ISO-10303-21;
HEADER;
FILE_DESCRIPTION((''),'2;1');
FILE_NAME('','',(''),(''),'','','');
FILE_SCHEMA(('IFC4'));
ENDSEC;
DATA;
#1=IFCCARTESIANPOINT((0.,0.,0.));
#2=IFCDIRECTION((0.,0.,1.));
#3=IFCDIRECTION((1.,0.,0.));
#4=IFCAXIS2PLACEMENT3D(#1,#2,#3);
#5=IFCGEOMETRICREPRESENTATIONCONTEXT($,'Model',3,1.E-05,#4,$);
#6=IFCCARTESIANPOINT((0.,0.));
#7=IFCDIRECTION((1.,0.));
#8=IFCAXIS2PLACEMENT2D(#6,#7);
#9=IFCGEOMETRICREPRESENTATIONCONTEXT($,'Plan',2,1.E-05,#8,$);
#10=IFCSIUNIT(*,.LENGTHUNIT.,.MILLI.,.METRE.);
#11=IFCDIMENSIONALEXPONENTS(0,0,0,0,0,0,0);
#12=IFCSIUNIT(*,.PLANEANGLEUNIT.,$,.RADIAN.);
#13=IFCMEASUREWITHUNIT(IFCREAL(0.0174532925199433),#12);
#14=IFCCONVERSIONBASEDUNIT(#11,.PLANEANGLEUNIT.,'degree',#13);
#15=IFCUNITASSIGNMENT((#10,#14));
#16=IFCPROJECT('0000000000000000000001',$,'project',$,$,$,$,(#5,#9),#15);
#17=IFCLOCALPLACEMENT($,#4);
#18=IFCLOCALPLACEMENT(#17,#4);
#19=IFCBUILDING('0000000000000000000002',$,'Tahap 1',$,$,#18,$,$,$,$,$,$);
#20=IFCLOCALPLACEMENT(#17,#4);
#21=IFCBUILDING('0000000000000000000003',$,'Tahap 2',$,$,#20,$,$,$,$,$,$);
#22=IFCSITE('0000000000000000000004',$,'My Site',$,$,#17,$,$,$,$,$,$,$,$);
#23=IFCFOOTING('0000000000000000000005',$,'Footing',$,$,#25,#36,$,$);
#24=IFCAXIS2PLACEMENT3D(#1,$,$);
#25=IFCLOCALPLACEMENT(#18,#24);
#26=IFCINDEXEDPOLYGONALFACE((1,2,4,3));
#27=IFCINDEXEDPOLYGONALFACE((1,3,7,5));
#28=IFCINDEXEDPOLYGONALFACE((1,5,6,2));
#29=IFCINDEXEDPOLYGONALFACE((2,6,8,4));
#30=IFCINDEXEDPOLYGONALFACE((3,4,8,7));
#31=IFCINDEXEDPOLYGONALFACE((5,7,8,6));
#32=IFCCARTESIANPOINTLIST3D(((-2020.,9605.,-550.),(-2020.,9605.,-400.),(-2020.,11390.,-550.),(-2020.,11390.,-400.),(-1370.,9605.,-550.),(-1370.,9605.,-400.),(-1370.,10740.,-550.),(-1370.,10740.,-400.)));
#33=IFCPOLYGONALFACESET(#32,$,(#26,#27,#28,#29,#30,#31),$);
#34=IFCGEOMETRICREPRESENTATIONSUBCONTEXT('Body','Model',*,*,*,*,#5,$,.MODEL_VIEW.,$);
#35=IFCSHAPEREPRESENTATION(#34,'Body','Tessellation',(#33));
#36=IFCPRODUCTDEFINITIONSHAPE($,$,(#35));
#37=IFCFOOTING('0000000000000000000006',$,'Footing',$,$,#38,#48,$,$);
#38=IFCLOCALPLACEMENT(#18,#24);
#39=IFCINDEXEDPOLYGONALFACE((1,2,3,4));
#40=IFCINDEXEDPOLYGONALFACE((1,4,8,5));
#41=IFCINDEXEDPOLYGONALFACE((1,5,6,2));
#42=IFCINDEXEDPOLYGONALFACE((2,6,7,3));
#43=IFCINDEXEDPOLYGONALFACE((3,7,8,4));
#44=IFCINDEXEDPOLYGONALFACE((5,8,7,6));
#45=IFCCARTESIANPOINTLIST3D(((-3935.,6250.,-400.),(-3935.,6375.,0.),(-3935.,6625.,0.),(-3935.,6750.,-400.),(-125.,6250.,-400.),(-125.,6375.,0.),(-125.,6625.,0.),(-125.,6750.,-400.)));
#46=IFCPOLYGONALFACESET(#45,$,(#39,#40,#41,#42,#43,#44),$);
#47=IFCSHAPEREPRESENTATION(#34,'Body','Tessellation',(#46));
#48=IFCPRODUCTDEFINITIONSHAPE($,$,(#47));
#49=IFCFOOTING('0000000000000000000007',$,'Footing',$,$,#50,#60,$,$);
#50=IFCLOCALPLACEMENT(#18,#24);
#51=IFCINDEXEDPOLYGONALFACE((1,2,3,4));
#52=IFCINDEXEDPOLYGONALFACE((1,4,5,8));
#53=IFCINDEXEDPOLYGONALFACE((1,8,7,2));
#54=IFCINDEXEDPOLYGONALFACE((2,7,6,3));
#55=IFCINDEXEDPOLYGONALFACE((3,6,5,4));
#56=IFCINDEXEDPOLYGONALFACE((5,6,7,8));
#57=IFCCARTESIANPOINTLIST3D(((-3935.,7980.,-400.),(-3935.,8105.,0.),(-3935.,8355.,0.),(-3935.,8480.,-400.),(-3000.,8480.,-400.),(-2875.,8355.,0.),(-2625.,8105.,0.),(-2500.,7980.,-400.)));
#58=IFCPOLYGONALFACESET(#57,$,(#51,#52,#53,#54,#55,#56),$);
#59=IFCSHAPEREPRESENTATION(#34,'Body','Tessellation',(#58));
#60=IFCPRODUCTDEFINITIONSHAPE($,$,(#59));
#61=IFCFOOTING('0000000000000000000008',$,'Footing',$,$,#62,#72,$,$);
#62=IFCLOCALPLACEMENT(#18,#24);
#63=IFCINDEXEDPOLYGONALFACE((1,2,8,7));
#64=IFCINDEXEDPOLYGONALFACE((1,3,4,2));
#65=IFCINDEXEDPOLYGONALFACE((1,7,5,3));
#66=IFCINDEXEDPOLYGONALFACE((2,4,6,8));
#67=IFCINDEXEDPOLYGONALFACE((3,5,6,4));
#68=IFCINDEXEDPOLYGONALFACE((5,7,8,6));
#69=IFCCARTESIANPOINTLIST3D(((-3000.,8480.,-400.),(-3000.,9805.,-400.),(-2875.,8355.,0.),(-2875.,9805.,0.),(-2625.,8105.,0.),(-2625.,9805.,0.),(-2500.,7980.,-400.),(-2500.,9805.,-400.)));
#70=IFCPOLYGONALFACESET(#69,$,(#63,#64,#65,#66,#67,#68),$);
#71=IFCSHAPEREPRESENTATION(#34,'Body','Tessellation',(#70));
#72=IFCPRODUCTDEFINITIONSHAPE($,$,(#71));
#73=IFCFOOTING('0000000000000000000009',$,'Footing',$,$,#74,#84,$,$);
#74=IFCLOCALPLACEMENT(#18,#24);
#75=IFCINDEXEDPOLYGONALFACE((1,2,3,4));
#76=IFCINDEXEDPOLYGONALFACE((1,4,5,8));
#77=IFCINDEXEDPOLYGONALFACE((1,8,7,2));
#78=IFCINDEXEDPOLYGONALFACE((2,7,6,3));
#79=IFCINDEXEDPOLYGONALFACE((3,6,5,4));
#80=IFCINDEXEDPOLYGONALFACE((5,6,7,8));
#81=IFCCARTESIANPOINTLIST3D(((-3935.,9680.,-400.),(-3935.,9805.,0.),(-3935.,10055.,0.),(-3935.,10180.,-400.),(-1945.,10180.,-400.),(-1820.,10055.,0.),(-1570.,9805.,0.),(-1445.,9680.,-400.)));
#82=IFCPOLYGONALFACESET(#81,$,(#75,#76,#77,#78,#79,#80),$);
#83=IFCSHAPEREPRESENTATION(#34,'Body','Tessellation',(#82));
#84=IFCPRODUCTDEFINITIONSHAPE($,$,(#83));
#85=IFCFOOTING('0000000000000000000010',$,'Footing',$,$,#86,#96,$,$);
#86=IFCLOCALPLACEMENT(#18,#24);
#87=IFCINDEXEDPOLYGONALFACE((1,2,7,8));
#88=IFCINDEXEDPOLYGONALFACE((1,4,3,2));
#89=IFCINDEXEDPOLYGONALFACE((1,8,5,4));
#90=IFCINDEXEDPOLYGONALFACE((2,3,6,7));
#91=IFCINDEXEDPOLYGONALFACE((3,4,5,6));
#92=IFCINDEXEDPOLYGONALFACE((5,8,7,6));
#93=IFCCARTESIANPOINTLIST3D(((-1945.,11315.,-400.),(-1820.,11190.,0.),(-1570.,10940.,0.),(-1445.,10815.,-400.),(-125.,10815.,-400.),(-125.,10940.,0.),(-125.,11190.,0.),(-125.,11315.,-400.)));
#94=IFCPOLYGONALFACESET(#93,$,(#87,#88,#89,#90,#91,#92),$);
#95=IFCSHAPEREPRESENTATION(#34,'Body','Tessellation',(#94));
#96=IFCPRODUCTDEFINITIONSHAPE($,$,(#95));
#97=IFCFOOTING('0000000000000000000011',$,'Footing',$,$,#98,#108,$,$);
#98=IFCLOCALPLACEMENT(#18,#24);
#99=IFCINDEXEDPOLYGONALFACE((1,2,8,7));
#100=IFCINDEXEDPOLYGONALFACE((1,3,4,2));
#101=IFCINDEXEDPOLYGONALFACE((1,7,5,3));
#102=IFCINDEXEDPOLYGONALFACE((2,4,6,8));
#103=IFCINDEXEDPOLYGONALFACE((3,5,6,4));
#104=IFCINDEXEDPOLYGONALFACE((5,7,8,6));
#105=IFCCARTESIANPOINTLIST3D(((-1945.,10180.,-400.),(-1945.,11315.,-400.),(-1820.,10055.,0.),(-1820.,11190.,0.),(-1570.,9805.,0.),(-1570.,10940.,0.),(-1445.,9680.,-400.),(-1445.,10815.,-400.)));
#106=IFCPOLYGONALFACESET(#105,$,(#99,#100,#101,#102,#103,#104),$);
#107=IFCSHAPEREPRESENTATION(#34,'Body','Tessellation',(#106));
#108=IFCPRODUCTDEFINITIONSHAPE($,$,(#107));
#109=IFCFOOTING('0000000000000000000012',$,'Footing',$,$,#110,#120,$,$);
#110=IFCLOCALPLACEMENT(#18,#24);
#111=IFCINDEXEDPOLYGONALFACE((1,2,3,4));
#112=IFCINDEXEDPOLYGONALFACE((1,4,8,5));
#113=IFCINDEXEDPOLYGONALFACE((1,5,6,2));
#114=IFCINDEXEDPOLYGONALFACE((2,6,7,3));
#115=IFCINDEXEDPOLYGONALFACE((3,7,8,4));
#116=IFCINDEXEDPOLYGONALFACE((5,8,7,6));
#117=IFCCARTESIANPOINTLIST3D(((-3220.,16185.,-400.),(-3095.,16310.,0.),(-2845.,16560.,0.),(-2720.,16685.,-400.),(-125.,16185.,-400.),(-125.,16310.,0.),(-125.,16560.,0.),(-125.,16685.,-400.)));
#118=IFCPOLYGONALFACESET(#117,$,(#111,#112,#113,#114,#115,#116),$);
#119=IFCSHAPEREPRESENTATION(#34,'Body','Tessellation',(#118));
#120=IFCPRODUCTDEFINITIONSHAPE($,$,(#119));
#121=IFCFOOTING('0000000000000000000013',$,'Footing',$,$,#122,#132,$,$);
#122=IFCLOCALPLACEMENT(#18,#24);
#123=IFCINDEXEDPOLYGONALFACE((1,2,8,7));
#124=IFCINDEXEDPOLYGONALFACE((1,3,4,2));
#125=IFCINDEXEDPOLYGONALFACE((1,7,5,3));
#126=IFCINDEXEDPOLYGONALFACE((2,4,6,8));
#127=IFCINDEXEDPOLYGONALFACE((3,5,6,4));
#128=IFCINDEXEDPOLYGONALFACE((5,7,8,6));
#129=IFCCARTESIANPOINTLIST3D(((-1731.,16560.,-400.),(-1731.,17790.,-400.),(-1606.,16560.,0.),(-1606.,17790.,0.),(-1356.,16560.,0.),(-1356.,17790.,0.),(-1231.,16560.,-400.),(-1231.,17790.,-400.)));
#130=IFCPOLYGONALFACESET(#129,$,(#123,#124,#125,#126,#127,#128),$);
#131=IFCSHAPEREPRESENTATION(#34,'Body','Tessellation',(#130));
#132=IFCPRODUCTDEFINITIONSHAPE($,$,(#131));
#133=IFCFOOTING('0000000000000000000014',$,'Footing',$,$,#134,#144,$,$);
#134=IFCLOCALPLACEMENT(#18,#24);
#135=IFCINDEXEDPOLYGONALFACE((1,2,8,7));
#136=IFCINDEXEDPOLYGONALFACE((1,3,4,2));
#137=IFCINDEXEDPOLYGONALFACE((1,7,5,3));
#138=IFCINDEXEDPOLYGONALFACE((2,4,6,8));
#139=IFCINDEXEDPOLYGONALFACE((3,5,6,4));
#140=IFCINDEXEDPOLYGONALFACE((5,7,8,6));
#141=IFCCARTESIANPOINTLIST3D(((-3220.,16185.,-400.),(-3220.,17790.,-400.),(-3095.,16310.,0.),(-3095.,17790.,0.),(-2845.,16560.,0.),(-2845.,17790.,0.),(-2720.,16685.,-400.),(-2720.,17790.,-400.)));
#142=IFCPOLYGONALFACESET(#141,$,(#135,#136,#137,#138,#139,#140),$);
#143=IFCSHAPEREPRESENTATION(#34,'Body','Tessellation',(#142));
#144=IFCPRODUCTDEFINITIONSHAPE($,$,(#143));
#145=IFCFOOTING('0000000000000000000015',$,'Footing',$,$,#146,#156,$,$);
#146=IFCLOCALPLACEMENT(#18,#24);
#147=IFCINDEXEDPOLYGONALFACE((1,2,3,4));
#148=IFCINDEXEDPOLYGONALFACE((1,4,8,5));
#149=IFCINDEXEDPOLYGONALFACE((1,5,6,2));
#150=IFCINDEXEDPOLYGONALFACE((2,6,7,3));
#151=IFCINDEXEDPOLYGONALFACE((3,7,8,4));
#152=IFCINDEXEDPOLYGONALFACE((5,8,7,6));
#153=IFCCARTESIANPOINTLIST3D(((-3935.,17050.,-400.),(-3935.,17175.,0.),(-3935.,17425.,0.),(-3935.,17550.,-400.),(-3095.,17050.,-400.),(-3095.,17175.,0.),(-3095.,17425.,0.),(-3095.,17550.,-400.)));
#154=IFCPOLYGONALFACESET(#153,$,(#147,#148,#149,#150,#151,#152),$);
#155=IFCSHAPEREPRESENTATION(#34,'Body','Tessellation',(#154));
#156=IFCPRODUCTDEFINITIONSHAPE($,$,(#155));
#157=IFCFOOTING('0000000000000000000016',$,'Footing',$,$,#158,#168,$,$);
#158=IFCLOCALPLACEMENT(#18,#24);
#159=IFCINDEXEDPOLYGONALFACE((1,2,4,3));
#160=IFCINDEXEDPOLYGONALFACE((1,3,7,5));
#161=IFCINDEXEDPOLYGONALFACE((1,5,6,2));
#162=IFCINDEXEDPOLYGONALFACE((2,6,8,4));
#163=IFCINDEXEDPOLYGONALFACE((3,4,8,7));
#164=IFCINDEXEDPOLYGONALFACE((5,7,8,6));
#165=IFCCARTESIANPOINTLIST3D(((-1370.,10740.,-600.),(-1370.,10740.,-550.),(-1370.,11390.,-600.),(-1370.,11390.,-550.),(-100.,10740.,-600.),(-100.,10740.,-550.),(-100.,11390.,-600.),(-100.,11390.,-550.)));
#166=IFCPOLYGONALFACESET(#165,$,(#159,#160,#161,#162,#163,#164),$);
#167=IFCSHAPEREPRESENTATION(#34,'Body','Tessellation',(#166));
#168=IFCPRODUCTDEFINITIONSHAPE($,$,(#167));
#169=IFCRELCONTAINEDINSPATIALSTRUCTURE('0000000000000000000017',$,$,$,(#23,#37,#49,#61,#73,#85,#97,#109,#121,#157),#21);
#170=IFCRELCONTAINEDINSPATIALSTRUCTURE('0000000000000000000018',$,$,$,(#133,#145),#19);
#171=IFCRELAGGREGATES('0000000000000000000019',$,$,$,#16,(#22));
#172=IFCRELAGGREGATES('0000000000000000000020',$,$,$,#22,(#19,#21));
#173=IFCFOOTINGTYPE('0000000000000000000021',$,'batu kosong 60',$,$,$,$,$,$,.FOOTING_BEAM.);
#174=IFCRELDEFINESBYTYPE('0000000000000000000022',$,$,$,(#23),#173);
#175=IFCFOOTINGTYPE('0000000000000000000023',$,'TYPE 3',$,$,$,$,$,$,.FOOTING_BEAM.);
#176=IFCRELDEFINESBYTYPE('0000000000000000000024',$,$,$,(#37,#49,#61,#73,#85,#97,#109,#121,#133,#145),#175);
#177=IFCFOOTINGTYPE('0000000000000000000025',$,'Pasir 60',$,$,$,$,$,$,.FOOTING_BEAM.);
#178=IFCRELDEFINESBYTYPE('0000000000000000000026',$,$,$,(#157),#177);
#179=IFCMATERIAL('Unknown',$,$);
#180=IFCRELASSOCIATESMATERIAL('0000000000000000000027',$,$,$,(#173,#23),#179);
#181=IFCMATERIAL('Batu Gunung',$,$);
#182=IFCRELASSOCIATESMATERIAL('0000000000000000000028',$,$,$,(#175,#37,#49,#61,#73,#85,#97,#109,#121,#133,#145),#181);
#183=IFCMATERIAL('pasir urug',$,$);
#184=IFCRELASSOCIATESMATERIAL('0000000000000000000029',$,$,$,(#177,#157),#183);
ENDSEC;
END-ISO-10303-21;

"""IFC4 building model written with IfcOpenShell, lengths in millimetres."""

from ifc_helpers import new_model, entity, si_unit, converted_unit, frame, origin_with_axes, origin_2d_with_axis, place, context, subcontext, project, spatial, indexed_curve, rectangle, outline, extrude, clip, halfspace, material, material_profile, profile_set, profile_usage, type_object, element, save


model = new_model("IFC4")

# Units and contexts
model_context = context("Model", 3, precision=1e-05, world=origin_with_axes())
plan_context = context("Plan", 2, precision=1e-05, world=origin_2d_with_axis())
body_context = subcontext(model_context, "Body", "Model", "MODEL_VIEW")
ifc_project = project(units=[si_unit("LENGTHUNIT", "METRE", prefix="MILLI"), converted_unit("PLANEANGLEUNIT", "degree", entity("IfcReal", 0.0174532925199433), si_unit("PLANEANGLEUNIT", "RADIAN"), dimensions=[0, 0, 0, 0, 0, 0, 0])], contexts=[model_context, plan_context])

# Site, building
site_placement = place(None, origin_with_axes())
site = spatial("IfcSite", under=ifc_project, at=site_placement, Name="My Site")
building_1_placement = place(site_placement, origin_with_axes())
building_1 = spatial("IfcBuilding", under=site, at=building_1_placement, Name="Tahap 1")

# Shared definitions
ifc_material_1 = material(Name="Batu Gunung")
ifc_material_2 = material(Name="Unknown")
ifc_material_profile_1 = material_profile(ifc_material_2, rectangle(XDim=650.0, YDim=150.0, kind="CURVE"))
ifc_profile_set_1 = profile_set([ifc_material_profile_1])
footing_type_1 = type_object("IfcFootingType", Name="batu kosong 60", PredefinedType="FOOTING_BEAM", material=ifc_profile_set_1)

# Shared definitions
building_2_placement = place(site_placement, origin_with_axes())
building_2 = spatial("IfcBuilding", under=site, at=building_2_placement, Name="Tahap 2")

# Footings
ifc_profile_usage_1 = profile_usage(ifc_profile_set_1, cardinal=8)
footing_1_placement = place(building_2_placement, frame((-1695.0, 11390.0, -400.0), z_axis=(0.0, -1.0, 0.0), x_axis=(1.0, 0.0, 0.0)))
element("IfcFooting", 1, at=footing_1_placement, inside=building_2, type_object=footing_type_1, material=ifc_profile_usage_1, Name="Footing", context=body_context, shape_type="Clipping", body=[
    clip(extrude(rectangle(XDim=650.0, YDim=150.0, kind="CURVE"), frame((0.0, -75.0, 0.0), z_axis=(0.0, 0.0, 1.0), x_axis=(1.0, 0.0, 0.0)), (0.0, 0.0, 1.0), 1785.0), halfspace(frame((-325.0, 400.0, 0.0), z_axis=(0.707107, 0.0, -0.707107), x_axis=(0.0, -1.0, 0.0)), False)),
])
ifc_material_profile_2 = material_profile(ifc_material_1, outline(indexed_curve([(-125.0, 0.0), (125.0, 0.0), (250.0, -400.0), (-250.0, -400.0), (-125.0, 0.0)])))
ifc_profile_set_2 = profile_set([ifc_material_profile_2])
ifc_profile_usage_2 = profile_usage(ifc_profile_set_2)
footing_type_2 = type_object("IfcFootingType", Name="TYPE 3", PredefinedType="FOOTING_BEAM", material=ifc_profile_set_2)
footing_2_placement = place(building_2_placement, frame((-3935.0, 6500.0, 0.0), z_axis=(1.0, 0.0, 0.0), x_axis=(0.0, 1.0, 0.0)))
element("IfcFooting", 2, at=footing_2_placement, inside=building_2, type_object=footing_type_2, material=ifc_profile_usage_2, Name="Footing", context=body_context, shape_type="SweptSolid", body=[
    extrude(outline(indexed_curve([(-125.0, 0.0), (125.0, 0.0), (250.0, -400.0), (-250.0, -400.0), (-125.0, 0.0)])), origin_with_axes(), (0.0, 0.0, 1.0), 3810.0),
])
ifc_profile_usage_3 = profile_usage(ifc_profile_set_2)
footing_3_placement = place(building_2_placement, frame((-3935.0, 8230.0, 0.0), z_axis=(1.0, 0.0, 0.0), x_axis=(0.0, 1.0, 0.0)))
element("IfcFooting", 3, at=footing_3_placement, inside=building_2, type_object=footing_type_2, material=ifc_profile_usage_3, Name="Footing", context=body_context, shape_type="Clipping", body=[
    clip(extrude(outline(indexed_curve([(-125.0, 0.0), (125.0, 0.0), (250.0, -400.0), (-250.0, -400.0), (-125.0, 0.0)])), origin_with_axes(), (0.0, 0.0, 1.0), 1435.0), halfspace(frame((-250.0, 0.0, 1435.0), z_axis=(0.707107, 0.0, 0.707107), x_axis=(0.0, -1.0, 0.0)), False)),
])
ifc_profile_usage_4 = profile_usage(ifc_profile_set_2)
footing_4_placement = place(building_2_placement, frame((-2750.0, 7980.0, 0.0), z_axis=(0.0, 1.0, 0.0), x_axis=(-1.0, 0.0, 0.0)))
element("IfcFooting", 4, at=footing_4_placement, inside=building_2, type_object=footing_type_2, material=ifc_profile_usage_4, Name="Footing", context=body_context, shape_type="Clipping", body=[
    clip(extrude(outline(indexed_curve([(-125.0, 0.0), (125.0, 0.0), (250.0, -400.0), (-250.0, -400.0), (-125.0, 0.0)])), origin_with_axes(), (0.0, 0.0, 1.0), 1825.0), halfspace(frame((-250.0, 0.0, 0.0), z_axis=(0.707107, 0.0, -0.707107), x_axis=(0.0, -1.0, 0.0)), False)),
])
ifc_profile_usage_5 = profile_usage(ifc_profile_set_2)
footing_5_placement = place(building_2_placement, frame((-1445.0, 9930.0, 0.0), z_axis=(-1.0, 0.0, 0.0), x_axis=(0.0, -1.0, 0.0)))
element("IfcFooting", 5, at=footing_5_placement, inside=building_2, type_object=footing_type_2, material=ifc_profile_usage_5, Name="Footing", context=body_context, shape_type="Clipping", body=[
    clip(extrude(outline(indexed_curve([(-125.0, 0.0), (125.0, 0.0), (250.0, -400.0), (-250.0, -400.0), (-125.0, 0.0)])), origin_with_axes(), (0.0, 0.0, 1.0), 2490.0), halfspace(frame((250.0, 0.0, 0.0), z_axis=(-0.707107, 0.0, -0.707107), x_axis=(0.0, 1.0, 0.0)), False)),
])
ifc_profile_usage_6 = profile_usage(ifc_profile_set_2)
footing_6_placement = place(building_2_placement, frame((-125.0, 11065.0, 0.0), z_axis=(-1.0, 0.0, 0.0), x_axis=(0.0, -1.0, 0.0)))
element("IfcFooting", 6, at=footing_6_placement, inside=building_2, type_object=footing_type_2, material=ifc_profile_usage_6, Name="Footing", context=body_context, shape_type="Clipping", body=[
    clip(extrude(outline(indexed_curve([(-125.0, 0.0), (125.0, 0.0), (250.0, -400.0), (-250.0, -400.0), (-125.0, 0.0)])), origin_with_axes(), (0.0, 0.0, 1.0), 1820.0), halfspace(frame((-250.0, 0.0, 1820.0), z_axis=(0.707107, 0.0, 0.707107), x_axis=(0.0, -1.0, 0.0)), False)),
])
ifc_profile_usage_7 = profile_usage(ifc_profile_set_2)
footing_7_placement = place(building_2_placement, frame((-1695.0, 11315.0, 0.0), z_axis=(0.0, -1.0, 0.0), x_axis=(1.0, 0.0, 0.0)))
element("IfcFooting", 7, at=footing_7_placement, inside=building_2, type_object=footing_type_2, material=ifc_profile_usage_7, Name="Footing", context=body_context, shape_type="Clipping", body=[
    clip(clip(extrude(outline(indexed_curve([(-125.0, 0.0), (125.0, 0.0), (250.0, -400.0), (-250.0, -400.0), (-125.0, 0.0)])), origin_with_axes(), (0.0, 0.0, 1.0), 1635.0), halfspace(frame((-250.0, 0.0, 0.0), z_axis=(0.707107, 0.0, -0.707107), x_axis=(0.0, -1.0, 0.0)), False)), halfspace(frame((250.0, 0.0, 1635.0), z_axis=(-0.707107, 0.0, 0.707107), x_axis=(0.0, 1.0, 0.0)), False)),
])
ifc_profile_usage_8 = profile_usage(ifc_profile_set_2)
footing_8_placement = place(building_2_placement, frame((-125.0, 16435.0, 0.0), z_axis=(-1.0, 0.0, 0.0), x_axis=(0.0, -1.0, 0.0)))
element("IfcFooting", 8, at=footing_8_placement, inside=building_2, type_object=footing_type_2, material=ifc_profile_usage_8, Name="Footing", context=body_context, shape_type="Clipping", body=[
    clip(extrude(outline(indexed_curve([(-125.0, 0.0), (125.0, 0.0), (250.0, -400.0), (-250.0, -400.0), (-125.0, 0.0)])), origin_with_axes(), (0.0, 0.0, 1.0), 3095.0), halfspace(frame((250.0, 0.0, 3095.0), z_axis=(-0.707107, 0.0, 0.707106), x_axis=(0.0, 1.0, 0.0)), False)),
])
ifc_profile_usage_9 = profile_usage(ifc_profile_set_2)
footing_9_placement = place(building_2_placement, frame((-1481.0, 16560.0, 0.0), z_axis=(0.0, 1.0, 0.0), x_axis=(-1.0, 0.0, 0.0)))
element("IfcFooting", 9, at=footing_9_placement, inside=building_2, type_object=footing_type_2, material=ifc_profile_usage_9, Name="Footing", context=body_context, shape_type="SweptSolid", body=[
    extrude(outline(indexed_curve([(-125.0, 0.0), (125.0, 0.0), (250.0, -400.0), (-250.0, -400.0), (-125.0, 0.0)])), origin_with_axes(), (0.0, 0.0, 1.0), 1230.0),
])
ifc_profile_usage_10 = profile_usage(ifc_profile_set_2)
footing_10_placement = place(building_1_placement, frame((-2970.0, 16185.0, 0.0), z_axis=(0.0, 1.0, 0.0), x_axis=(-1.0, 0.0, 0.0)))
element("IfcFooting", 10, at=footing_10_placement, inside=building_1, type_object=footing_type_2, material=ifc_profile_usage_10, Name="Footing", context=body_context, shape_type="Clipping", body=[
    clip(extrude(outline(indexed_curve([(-125.0, 0.0), (125.0, 0.0), (250.0, -400.0), (-250.0, -400.0), (-125.0, 0.0)])), origin_with_axes(), (0.0, 0.0, 1.0), 1605.0), halfspace(frame((250.0, 0.0, 0.0), z_axis=(-0.707107, 0.0, -0.707107), x_axis=(0.0, 1.0, 0.0)), False)),
])
ifc_profile_usage_11 = profile_usage(ifc_profile_set_2)
footing_11_placement = place(building_1_placement, frame((-3095.0, 17300.0, 0.0), z_axis=(-1.0, 0.0, 0.0), x_axis=(0.0, -1.0, 0.0)))
element("IfcFooting", 11, at=footing_11_placement, inside=building_1, type_object=footing_type_2, material=ifc_profile_usage_11, Name="Footing", context=body_context, shape_type="SweptSolid", body=[
    extrude(outline(indexed_curve([(-125.0, 0.0), (125.0, 0.0), (250.0, -400.0), (-250.0, -400.0), (-125.0, 0.0)])), origin_with_axes(), (0.0, 0.0, 1.0), 840.0),
])
ifc_material_3 = material(Name="pasir urug")
ifc_material_profile_3 = material_profile(ifc_material_3, rectangle(XDim=650.0, YDim=50.0, kind="CURVE"))
ifc_profile_set_3 = profile_set([ifc_material_profile_3])
ifc_profile_usage_12 = profile_usage(ifc_profile_set_3, cardinal=8)
footing_type_3 = type_object("IfcFootingType", Name="Pasir 60", PredefinedType="FOOTING_BEAM", material=ifc_profile_set_3)
footing_12_placement = place(building_2_placement, frame((-100.0, 11065.0, -550.0), z_axis=(-1.0, 0.0, 0.0), x_axis=(0.0, -1.0, 0.0)))
element("IfcFooting", 12, at=footing_12_placement, inside=building_2, type_object=footing_type_3, material=ifc_profile_usage_12, Name="Footing", context=body_context, shape_type="SweptSolid", body=[
    extrude(rectangle(XDim=650.0, YDim=50.0, kind="CURVE"), frame((0.0, -25.0, 0.0), z_axis=(0.0, 0.0, 1.0), x_axis=(1.0, 0.0, 0.0)), (0.0, 0.0, 1.0), 1270.0),
])

save(model, "model.ifc")
